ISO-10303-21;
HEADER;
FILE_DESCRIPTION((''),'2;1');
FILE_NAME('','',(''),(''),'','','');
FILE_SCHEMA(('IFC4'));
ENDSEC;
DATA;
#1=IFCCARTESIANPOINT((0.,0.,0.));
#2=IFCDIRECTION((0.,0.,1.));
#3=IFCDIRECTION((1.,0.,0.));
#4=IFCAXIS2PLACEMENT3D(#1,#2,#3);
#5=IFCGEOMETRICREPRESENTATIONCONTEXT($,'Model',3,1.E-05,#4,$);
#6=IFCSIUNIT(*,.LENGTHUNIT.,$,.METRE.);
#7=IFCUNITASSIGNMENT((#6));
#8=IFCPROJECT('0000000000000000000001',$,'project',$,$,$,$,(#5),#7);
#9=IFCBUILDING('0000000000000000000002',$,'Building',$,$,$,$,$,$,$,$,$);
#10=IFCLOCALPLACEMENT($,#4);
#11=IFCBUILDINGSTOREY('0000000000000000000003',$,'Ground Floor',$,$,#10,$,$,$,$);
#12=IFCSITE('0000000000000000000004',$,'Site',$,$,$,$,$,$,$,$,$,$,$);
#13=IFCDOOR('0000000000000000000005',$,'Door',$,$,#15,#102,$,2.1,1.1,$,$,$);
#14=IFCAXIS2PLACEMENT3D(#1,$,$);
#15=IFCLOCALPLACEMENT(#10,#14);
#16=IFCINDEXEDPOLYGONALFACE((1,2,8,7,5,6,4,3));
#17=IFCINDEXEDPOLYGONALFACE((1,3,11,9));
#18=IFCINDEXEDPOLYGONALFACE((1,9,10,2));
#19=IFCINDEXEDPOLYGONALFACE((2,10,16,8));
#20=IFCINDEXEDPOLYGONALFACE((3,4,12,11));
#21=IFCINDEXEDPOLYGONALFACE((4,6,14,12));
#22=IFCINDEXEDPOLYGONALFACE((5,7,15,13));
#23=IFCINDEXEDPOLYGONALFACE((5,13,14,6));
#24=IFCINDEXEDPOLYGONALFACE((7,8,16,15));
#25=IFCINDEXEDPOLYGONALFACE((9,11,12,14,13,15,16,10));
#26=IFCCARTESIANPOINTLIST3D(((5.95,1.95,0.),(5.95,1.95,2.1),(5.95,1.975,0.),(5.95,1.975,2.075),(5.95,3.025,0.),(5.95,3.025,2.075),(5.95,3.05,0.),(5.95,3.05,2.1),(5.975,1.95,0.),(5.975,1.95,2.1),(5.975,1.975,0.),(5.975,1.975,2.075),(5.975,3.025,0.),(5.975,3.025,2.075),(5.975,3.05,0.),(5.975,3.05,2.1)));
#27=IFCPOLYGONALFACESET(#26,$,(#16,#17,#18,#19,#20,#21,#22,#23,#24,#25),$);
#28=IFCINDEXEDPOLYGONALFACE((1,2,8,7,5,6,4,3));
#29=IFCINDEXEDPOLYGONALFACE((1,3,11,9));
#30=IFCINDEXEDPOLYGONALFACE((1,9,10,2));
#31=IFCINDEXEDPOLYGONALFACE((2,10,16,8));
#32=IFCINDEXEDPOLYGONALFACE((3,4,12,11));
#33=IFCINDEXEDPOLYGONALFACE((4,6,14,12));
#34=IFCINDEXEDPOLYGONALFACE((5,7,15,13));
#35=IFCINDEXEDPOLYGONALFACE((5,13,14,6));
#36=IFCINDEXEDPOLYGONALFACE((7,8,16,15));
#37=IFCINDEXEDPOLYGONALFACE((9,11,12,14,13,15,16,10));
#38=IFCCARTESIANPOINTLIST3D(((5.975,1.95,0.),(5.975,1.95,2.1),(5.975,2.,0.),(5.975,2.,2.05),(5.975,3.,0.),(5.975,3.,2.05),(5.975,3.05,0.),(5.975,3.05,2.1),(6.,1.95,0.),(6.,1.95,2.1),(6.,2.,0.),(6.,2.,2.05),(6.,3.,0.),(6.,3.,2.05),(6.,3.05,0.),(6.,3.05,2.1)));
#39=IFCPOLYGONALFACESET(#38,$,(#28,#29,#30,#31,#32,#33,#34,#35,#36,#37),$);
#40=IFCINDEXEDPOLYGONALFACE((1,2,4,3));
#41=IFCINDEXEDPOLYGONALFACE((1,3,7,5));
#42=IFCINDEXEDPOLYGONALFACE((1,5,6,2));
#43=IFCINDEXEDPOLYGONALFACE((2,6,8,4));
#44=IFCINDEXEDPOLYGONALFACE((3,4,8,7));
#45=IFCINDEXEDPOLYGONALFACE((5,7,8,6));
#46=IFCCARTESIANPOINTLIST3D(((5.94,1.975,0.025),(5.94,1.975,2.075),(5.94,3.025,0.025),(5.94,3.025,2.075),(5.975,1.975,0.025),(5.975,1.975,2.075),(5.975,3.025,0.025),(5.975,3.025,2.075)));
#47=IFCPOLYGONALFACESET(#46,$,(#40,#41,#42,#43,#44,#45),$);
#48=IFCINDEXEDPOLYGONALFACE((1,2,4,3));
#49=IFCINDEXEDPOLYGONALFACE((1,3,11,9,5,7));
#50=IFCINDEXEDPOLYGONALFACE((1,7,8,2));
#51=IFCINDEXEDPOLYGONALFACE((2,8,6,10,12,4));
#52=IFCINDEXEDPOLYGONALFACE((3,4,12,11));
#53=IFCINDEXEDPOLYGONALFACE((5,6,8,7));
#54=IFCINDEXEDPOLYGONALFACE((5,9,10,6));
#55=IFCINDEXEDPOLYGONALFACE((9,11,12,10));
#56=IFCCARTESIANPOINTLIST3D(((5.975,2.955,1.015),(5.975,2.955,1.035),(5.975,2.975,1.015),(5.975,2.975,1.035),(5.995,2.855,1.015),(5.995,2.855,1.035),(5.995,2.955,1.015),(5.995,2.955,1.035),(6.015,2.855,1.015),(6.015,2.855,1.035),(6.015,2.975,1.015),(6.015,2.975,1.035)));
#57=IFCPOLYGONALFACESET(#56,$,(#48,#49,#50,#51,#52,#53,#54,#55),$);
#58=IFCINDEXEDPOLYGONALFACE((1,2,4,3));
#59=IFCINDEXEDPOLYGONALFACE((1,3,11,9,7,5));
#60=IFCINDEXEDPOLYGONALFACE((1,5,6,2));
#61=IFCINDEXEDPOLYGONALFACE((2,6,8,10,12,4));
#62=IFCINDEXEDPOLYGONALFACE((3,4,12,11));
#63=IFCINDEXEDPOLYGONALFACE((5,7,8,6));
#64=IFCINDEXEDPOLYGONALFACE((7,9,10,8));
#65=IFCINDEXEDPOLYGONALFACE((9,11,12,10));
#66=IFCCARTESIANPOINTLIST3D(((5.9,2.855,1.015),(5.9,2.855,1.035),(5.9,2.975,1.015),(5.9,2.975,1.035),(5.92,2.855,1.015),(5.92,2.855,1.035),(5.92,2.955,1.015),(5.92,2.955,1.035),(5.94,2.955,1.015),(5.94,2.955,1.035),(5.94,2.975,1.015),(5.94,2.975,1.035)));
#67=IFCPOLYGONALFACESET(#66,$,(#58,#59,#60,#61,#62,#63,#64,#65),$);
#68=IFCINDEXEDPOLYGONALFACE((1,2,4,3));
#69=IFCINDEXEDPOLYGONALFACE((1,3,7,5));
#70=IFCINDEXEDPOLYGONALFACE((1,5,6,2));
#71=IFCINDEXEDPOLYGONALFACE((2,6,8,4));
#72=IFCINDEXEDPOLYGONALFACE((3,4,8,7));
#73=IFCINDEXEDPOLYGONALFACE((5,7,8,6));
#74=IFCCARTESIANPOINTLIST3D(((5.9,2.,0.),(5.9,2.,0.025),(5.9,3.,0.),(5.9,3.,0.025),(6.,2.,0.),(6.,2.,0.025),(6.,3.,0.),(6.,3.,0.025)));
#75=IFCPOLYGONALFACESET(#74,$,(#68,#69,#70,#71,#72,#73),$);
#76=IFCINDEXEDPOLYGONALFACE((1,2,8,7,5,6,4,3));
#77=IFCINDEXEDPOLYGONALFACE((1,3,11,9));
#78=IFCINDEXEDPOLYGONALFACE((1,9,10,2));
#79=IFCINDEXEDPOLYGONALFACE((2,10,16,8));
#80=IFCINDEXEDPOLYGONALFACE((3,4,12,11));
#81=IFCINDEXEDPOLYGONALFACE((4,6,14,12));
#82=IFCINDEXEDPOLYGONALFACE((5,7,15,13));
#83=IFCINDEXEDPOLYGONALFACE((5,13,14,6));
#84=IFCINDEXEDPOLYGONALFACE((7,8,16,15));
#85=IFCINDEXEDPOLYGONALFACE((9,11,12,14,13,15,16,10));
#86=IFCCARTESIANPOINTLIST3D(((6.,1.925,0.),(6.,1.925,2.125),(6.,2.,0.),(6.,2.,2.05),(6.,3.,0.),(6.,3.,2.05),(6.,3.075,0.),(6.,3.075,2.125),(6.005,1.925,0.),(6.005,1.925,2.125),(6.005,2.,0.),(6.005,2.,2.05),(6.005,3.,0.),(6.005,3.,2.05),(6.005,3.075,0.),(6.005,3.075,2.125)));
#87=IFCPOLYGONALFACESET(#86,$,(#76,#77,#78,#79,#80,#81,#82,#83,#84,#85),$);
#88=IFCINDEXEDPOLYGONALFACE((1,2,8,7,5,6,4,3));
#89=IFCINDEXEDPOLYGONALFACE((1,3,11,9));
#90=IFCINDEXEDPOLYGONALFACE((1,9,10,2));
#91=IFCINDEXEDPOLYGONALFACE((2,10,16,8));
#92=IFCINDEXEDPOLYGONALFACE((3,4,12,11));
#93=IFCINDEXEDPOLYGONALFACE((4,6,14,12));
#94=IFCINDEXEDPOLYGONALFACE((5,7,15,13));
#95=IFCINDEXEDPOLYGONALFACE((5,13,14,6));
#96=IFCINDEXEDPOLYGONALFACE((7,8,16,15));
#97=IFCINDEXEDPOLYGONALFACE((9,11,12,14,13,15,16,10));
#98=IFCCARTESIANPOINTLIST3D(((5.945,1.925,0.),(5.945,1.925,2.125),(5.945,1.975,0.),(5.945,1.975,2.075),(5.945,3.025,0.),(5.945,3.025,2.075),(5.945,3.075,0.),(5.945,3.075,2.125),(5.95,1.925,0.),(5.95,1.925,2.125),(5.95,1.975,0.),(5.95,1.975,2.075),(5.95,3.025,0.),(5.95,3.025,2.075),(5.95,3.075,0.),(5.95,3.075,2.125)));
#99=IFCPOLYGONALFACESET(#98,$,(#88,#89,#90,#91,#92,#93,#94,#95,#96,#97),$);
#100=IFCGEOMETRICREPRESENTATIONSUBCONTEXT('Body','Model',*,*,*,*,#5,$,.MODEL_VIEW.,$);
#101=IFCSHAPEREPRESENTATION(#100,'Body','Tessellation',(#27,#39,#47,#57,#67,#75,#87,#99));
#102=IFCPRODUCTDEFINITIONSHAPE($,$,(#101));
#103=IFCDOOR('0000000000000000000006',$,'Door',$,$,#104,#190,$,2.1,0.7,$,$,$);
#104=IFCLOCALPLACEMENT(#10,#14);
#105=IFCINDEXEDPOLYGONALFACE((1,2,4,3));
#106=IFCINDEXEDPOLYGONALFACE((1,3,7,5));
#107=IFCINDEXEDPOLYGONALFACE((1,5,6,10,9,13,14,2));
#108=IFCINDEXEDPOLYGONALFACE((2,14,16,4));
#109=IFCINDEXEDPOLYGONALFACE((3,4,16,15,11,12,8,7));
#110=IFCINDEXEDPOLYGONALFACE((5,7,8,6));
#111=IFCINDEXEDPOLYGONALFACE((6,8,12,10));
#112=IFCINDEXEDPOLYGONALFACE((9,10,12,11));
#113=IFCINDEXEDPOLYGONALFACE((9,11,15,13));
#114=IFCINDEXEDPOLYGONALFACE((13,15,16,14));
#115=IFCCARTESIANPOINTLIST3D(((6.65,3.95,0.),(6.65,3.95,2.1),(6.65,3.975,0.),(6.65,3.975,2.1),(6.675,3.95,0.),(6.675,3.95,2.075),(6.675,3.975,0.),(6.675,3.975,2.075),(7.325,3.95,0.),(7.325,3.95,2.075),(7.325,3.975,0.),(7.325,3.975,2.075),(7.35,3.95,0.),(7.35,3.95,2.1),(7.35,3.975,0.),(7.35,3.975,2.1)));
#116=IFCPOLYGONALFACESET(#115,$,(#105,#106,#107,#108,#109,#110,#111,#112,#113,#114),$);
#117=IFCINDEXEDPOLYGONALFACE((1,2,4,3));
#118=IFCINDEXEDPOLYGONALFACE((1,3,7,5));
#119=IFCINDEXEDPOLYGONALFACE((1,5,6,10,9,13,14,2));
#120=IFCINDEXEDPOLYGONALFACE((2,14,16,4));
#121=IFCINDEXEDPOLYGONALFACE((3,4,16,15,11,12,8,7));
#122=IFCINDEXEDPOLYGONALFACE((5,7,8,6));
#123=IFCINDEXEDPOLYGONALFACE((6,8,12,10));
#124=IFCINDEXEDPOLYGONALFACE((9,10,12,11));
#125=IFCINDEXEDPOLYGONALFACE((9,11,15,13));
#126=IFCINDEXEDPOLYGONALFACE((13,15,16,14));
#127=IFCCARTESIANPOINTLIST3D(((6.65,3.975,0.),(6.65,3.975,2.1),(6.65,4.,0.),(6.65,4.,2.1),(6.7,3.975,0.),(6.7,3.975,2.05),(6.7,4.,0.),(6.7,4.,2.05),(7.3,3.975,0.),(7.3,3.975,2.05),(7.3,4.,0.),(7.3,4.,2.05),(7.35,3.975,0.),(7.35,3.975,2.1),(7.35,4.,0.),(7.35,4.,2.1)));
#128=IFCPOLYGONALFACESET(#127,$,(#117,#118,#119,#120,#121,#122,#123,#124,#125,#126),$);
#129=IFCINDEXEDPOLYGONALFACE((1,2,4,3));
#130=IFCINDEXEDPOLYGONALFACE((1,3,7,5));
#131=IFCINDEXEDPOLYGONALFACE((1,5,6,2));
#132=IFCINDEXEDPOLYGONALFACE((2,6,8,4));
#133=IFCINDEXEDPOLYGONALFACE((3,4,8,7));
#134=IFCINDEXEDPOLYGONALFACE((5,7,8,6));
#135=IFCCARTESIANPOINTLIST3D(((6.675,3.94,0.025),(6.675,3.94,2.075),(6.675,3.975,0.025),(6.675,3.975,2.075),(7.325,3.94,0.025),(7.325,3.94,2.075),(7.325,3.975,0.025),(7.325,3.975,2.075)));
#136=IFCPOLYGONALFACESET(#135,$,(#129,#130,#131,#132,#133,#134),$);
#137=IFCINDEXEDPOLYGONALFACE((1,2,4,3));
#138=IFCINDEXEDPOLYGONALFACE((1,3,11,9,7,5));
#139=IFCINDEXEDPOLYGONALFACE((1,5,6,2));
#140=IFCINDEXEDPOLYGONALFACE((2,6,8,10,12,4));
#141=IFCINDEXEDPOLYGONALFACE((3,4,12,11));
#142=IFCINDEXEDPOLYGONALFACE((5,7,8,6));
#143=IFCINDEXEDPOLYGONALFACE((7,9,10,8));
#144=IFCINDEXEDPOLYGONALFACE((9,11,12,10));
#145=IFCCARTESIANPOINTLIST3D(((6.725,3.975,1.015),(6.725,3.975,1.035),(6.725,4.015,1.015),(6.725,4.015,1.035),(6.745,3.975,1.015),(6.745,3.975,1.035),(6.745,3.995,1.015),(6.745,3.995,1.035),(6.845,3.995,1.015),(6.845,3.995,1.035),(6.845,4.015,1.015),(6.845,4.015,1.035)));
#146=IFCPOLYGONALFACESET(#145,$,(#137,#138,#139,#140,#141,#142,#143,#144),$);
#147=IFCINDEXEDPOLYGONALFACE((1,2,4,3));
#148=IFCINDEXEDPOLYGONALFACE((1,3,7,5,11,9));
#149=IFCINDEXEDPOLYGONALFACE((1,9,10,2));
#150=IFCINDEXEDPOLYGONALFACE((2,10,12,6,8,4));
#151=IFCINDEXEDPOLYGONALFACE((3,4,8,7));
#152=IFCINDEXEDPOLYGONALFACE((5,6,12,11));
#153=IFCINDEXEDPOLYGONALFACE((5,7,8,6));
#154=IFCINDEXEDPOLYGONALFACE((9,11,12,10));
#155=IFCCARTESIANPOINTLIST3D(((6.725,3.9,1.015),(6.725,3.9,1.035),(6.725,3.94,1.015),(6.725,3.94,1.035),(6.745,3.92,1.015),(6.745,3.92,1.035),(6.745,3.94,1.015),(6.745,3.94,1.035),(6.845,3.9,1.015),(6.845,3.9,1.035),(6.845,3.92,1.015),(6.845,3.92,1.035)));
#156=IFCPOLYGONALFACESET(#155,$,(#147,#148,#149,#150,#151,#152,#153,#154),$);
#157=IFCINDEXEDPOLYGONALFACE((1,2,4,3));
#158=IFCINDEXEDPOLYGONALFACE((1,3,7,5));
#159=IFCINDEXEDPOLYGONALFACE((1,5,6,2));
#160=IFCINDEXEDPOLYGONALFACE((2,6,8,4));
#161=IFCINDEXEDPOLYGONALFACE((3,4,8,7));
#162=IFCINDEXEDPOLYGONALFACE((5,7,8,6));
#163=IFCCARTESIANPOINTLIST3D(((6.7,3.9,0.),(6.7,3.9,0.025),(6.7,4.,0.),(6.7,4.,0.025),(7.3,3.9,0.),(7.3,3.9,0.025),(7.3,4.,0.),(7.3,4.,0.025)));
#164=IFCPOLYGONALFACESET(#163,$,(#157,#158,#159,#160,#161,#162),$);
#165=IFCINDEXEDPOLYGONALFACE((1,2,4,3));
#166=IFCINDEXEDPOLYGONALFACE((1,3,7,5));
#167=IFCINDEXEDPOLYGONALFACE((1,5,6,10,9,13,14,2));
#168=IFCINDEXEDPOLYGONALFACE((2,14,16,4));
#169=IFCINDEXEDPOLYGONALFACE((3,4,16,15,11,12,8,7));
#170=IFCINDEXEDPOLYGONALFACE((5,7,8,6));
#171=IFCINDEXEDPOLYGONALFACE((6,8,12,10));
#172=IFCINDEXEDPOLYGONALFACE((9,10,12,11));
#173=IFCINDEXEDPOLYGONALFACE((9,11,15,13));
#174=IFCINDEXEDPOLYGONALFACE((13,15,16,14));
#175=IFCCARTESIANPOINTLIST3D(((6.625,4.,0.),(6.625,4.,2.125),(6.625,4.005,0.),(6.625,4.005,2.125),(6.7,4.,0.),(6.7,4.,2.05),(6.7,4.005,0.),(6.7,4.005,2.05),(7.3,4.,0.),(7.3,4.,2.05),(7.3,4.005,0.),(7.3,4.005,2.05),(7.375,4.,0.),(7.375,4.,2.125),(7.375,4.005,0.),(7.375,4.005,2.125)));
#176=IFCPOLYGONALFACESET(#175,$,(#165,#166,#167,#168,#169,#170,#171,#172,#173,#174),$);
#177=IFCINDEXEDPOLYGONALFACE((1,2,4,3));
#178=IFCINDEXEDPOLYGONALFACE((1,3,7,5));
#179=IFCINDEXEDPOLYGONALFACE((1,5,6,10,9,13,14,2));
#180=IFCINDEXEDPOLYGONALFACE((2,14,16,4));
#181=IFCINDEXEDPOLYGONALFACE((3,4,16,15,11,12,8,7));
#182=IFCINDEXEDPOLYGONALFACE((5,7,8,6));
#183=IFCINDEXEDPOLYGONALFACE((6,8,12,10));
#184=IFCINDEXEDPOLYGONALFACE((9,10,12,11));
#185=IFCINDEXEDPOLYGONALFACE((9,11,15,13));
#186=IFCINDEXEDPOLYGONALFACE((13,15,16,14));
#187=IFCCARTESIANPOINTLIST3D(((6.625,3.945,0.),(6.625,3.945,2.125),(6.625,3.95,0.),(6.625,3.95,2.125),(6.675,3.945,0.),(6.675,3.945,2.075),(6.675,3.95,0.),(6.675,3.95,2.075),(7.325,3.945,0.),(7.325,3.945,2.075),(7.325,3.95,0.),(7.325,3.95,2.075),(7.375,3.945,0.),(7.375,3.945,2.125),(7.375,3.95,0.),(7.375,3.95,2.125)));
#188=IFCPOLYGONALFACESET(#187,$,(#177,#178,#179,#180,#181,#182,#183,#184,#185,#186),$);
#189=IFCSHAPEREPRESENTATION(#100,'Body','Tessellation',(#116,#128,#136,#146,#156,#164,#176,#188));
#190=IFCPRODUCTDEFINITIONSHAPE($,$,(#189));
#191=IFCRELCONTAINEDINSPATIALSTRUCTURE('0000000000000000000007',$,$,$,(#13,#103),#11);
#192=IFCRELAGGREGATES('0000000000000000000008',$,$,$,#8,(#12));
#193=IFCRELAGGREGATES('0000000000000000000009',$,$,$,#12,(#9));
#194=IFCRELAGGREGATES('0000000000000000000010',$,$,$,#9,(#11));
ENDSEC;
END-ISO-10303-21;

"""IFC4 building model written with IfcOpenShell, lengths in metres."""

from ifc_helpers import new_model, si_unit, frame, origin_with_axes, place, context, subcontext, project, spatial, line, indexed_curve, outline, extrude, element, save


model = new_model("IFC4")

# Units and contexts
model_context = context("Model", 3, precision=1e-05, world=origin_with_axes())
body_context = subcontext(model_context, "Body", "Model", "MODEL_VIEW")
ifc_project = project(units=[si_unit("LENGTHUNIT", "METRE")], contexts=[model_context])

# Site, building, storey
site = spatial("IfcSite", under=ifc_project, Name="Site")
building = spatial("IfcBuilding", under=site, Name="Building")
storey_placement = place(None, origin_with_axes())
storey = spatial("IfcBuildingStorey", under=building, at=storey_placement, Name="Ground Floor")

# Doors
door_1_placement = place(storey_placement, frame((6.0, 1.95, 0.0), z_axis=(0.0, 0.0, 1.0), x_axis=(0.0, 1.0, 0.0)))
element("IfcDoor", 1, at=door_1_placement, inside=storey, Name="Door", OverallHeight=2.1, OverallWidth=1.1, context=body_context, shape_type="SweptSolid", body=[
    extrude(outline(indexed_curve([(0.0, 0.0), (0.0, 2.1), (1.1, 2.1), (1.1, 0.0), (1.075, 0.0), (1.075, 2.075), (0.025, 2.075), (0.025, 0.0)], segments=[line(1, 2, 3, 4, 5, 6, 7, 8, 1)])), frame((0.0, 0.025, 0.0), z_axis=(0.0, -1.0, 0.0), x_axis=(1.0, 0.0, 0.0)), (0.0, 0.0, -1.0), 0.025),
    extrude(outline(indexed_curve([(0.0, 0.0), (0.0, 2.1), (1.1, 2.1), (1.1, 0.0), (1.05, 0.0), (1.05, 2.05), (0.05, 2.05), (0.05, 0.0)], segments=[line(1, 2, 3, 4, 5, 6, 7, 8, 1)])), frame((0.0, 0.0, 0.0), z_axis=(0.0, -1.0, 0.0), x_axis=(1.0, 0.0, 0.0)), (0.0, 0.0, -1.0), 0.025),
    extrude(outline(indexed_curve([(0.0, 0.0), (1.05, 0.0), (1.05, 0.035), (0.0, 0.035)], segments=[line(1, 2, 3, 4, 1)])), frame((0.025, 0.025, 0.025), z_axis=(0.0, 0.0, 1.0), x_axis=(1.0, 0.0, 0.0)), (0.0, 0.0, 1.0), 2.05),
    extrude(outline(indexed_curve([(0.0, 0.0), (0.0, -0.04), (-0.12, -0.04), (-0.12, -0.02), (-0.02, -0.02), (-0.02, 0.0)], segments=[line(1, 2, 3, 4, 5, 6, 1)])), frame((1.025, 0.025, 1.015), z_axis=(0.0, 0.0, 1.0), x_axis=(1.0, 0.0, 0.0)), (0.0, 0.0, 1.0), 0.02),
    extrude(outline(indexed_curve([(0.0, 0.0), (0.0, 0.04), (-0.12, 0.04), (-0.12, 0.02), (-0.02, 0.02), (-0.02, 0.0)], segments=[line(1, 2, 3, 4, 5, 6, 1)])), frame((1.025, 0.06, 1.015), z_axis=(0.0, 0.0, 1.0), x_axis=(1.0, 0.0, 0.0)), (0.0, 0.0, 1.0), 0.02),
    extrude(outline(indexed_curve([(0.0, 0.0), (1.0, 0.0), (1.0, 0.1), (0.0, 0.1)], segments=[line(1, 2, 3, 4, 1)])), frame((0.05, 0.0, 0.0), z_axis=(0.0, 0.0, 1.0), x_axis=(1.0, 0.0, 0.0)), (0.0, 0.0, 1.0), 0.025),
    extrude(outline(indexed_curve([(0.0, 0.0), (0.0, 2.125), (1.15, 2.125), (1.15, 0.0), (1.075, 0.0), (1.075, 2.05), (0.075, 2.05), (0.075, 0.0)], segments=[line(1, 2, 3, 4, 5, 6, 7, 8, 1)])), frame((-0.025, -0.005, 0.0), z_axis=(0.0, -1.0, 0.0), x_axis=(1.0, 0.0, 0.0)), (0.0, 0.0, -1.0), 0.005),
    extrude(outline(indexed_curve([(0.0, 0.0), (0.0, 2.125), (1.15, 2.125), (1.15, 0.0), (1.1, 0.0), (1.1, 2.075), (0.05, 2.075), (0.05, 0.0)], segments=[line(1, 2, 3, 4, 5, 6, 7, 8, 1)])), frame((-0.025, 0.05, 0.0), z_axis=(0.0, -1.0, 0.0), x_axis=(1.0, 0.0, 0.0)), (0.0, 0.0, -1.0), 0.005),
])
door_2_placement = place(storey_placement, frame((7.35, 4.0, 0.0), z_axis=(0.0, 0.0, 1.0), x_axis=(-1.0, 0.0, 0.0)))
element("IfcDoor", 2, at=door_2_placement, inside=storey, Name="Door", OverallHeight=2.1, OverallWidth=0.7, context=body_context, shape_type="SweptSolid", body=[
    extrude(outline(indexed_curve([(0.0, 0.0), (0.0, 2.1), (0.7, 2.1), (0.7, 0.0), (0.675, 0.0), (0.675, 2.075), (0.025, 2.075), (0.025, 0.0)], segments=[line(1, 2, 3, 4, 5, 6, 7, 8, 1)])), frame((0.0, 0.025, 0.0), z_axis=(0.0, -1.0, 0.0), x_axis=(1.0, 0.0, 0.0)), (0.0, 0.0, -1.0), 0.025),
    extrude(outline(indexed_curve([(0.0, 0.0), (0.0, 2.1), (0.7, 2.1), (0.7, 0.0), (0.65, 0.0), (0.65, 2.05), (0.05, 2.05), (0.05, 0.0)], segments=[line(1, 2, 3, 4, 5, 6, 7, 8, 1)])), frame((0.0, 0.0, 0.0), z_axis=(0.0, -1.0, 0.0), x_axis=(1.0, 0.0, 0.0)), (0.0, 0.0, -1.0), 0.025),
    extrude(outline(indexed_curve([(0.0, 0.0), (0.65, 0.0), (0.65, 0.035), (0.0, 0.035)], segments=[line(1, 2, 3, 4, 1)])), frame((0.025, 0.025, 0.025), z_axis=(0.0, 0.0, 1.0), x_axis=(1.0, 0.0, 0.0)), (0.0, 0.0, 1.0), 2.05),
    extrude(outline(indexed_curve([(0.0, 0.0), (0.0, -0.04), (-0.12, -0.04), (-0.12, -0.02), (-0.02, -0.02), (-0.02, 0.0)], segments=[line(1, 2, 3, 4, 5, 6, 1)])), frame((0.625, 0.025, 1.015), z_axis=(0.0, 0.0, 1.0), x_axis=(1.0, 0.0, 0.0)), (0.0, 0.0, 1.0), 0.02),
    extrude(outline(indexed_curve([(0.0, 0.0), (0.0, 0.04), (-0.12, 0.04), (-0.12, 0.02), (-0.02, 0.02), (-0.02, 0.0)], segments=[line(1, 2, 3, 4, 5, 6, 1)])), frame((0.625, 0.06, 1.015), z_axis=(0.0, 0.0, 1.0), x_axis=(1.0, 0.0, 0.0)), (0.0, 0.0, 1.0), 0.02),
    extrude(outline(indexed_curve([(0.0, 0.0), (0.6, 0.0), (0.6, 0.1), (0.0, 0.1)], segments=[line(1, 2, 3, 4, 1)])), frame((0.05, 0.0, 0.0), z_axis=(0.0, 0.0, 1.0), x_axis=(1.0, 0.0, 0.0)), (0.0, 0.0, 1.0), 0.025),
    extrude(outline(indexed_curve([(0.0, 0.0), (0.0, 2.125), (0.75, 2.125), (0.75, 0.0), (0.675, 0.0), (0.675, 2.05), (0.075, 2.05), (0.075, 0.0)], segments=[line(1, 2, 3, 4, 5, 6, 7, 8, 1)])), frame((-0.025, -0.005, 0.0), z_axis=(0.0, -1.0, 0.0), x_axis=(1.0, 0.0, 0.0)), (0.0, 0.0, -1.0), 0.005),
    extrude(outline(indexed_curve([(0.0, 0.0), (0.0, 2.125), (0.75, 2.125), (0.75, 0.0), (0.7, 0.0), (0.7, 2.075), (0.05, 2.075), (0.05, 0.0)], segments=[line(1, 2, 3, 4, 5, 6, 7, 8, 1)])), frame((-0.025, 0.05, 0.0), z_axis=(0.0, -1.0, 0.0), x_axis=(1.0, 0.0, 0.0)), (0.0, 0.0, -1.0), 0.005),
])

save(model, "model.ifc")
